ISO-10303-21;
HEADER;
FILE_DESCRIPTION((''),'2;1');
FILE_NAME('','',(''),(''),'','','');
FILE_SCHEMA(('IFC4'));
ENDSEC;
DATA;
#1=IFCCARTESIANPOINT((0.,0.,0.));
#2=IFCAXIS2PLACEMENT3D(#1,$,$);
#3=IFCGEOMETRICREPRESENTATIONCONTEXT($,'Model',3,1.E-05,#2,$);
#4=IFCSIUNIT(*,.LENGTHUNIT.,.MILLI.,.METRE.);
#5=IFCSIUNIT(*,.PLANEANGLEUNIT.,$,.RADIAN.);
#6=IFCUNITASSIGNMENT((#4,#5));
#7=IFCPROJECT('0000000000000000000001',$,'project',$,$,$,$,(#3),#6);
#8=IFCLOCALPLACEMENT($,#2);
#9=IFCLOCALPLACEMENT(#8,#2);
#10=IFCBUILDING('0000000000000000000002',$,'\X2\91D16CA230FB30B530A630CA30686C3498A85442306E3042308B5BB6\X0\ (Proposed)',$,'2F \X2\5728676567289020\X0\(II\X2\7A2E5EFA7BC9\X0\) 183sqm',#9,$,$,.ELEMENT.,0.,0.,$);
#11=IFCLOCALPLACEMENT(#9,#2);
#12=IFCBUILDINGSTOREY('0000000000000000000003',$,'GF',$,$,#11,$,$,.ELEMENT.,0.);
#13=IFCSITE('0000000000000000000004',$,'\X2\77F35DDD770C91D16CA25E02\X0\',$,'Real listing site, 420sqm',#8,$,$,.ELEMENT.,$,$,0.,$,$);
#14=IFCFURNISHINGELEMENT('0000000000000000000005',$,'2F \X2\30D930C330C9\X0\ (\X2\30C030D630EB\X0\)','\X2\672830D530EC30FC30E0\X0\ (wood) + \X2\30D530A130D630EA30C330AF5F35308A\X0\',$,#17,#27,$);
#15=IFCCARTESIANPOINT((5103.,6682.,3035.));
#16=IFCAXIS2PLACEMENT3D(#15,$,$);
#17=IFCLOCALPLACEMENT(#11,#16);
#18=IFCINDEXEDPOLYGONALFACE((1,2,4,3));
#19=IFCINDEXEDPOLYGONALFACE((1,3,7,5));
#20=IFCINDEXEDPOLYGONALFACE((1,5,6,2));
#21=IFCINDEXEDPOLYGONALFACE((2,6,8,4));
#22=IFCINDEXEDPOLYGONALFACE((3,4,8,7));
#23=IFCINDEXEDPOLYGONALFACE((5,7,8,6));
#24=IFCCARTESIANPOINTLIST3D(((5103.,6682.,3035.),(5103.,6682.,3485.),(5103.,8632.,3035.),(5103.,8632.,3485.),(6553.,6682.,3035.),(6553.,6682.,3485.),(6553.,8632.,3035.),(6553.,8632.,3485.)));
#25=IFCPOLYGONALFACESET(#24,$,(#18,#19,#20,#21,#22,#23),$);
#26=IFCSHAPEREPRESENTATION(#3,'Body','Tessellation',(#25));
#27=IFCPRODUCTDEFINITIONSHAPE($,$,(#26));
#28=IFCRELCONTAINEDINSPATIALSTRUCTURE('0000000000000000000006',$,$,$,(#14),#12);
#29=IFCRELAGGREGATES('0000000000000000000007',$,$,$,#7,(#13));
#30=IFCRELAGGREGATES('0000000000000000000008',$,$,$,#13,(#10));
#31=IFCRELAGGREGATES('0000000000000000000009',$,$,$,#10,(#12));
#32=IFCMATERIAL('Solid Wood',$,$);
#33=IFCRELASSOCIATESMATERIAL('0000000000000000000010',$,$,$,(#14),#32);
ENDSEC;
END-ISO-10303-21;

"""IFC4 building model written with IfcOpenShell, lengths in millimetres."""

from ifc_helpers import new_model, si_unit, frame, frame_2d, origin, place, context, project, spatial, rectangle, extrude, material, element, save


model = new_model("IFC4")

# Units and contexts
model_context = context("Model", 3, precision=1e-05, world=origin())
ifc_project = project(units=[si_unit("LENGTHUNIT", "METRE", prefix="MILLI"), si_unit("PLANEANGLEUNIT", "RADIAN")], contexts=[model_context])

# Site, building, storey
site_placement = place(None, origin())
site = spatial("IfcSite", under=ifc_project, at=site_placement, Name="石川県金沢市", ObjectType="Real listing site, 420sqm", CompositionType="ELEMENT", RefElevation=0.0)
building_placement = place(site_placement, origin())
building = spatial("IfcBuilding", under=site, at=building_placement, Name="金沢・サウナと水風呂のある家 (Proposed)", ObjectType="2F 在来木造(II種建築) 183sqm", CompositionType="ELEMENT", ElevationOfRefHeight=0.0, ElevationOfTerrain=0.0)
storey_placement = place(building_placement, origin())
storey = spatial("IfcBuildingStorey", under=building, at=storey_placement, Name="GF", CompositionType="ELEMENT", Elevation=0.0)

# Shared definitions
ifc_material_1 = material(Name="Solid Wood")

# Furnishing element
furnishing_1_placement = place(storey_placement, frame((5103.0, 6682.0, 3035.0)))
element("IfcFurnishingElement", 1, at=furnishing_1_placement, inside=storey, material=ifc_material_1, Name="2F ベッド (ダブル)", Description="木フレーム (wood) + ファブリック張り", context=model_context, shape_type="SweptSolid", body=[
    extrude(rectangle(XDim=1450.0, YDim=1950.0, at=frame_2d((725.0, 975.0))), frame((5103.0, 6682.0, 3035.0)), (0.0, 0.0, 1.0), 450.0),
])

save(model, "model.ifc")
